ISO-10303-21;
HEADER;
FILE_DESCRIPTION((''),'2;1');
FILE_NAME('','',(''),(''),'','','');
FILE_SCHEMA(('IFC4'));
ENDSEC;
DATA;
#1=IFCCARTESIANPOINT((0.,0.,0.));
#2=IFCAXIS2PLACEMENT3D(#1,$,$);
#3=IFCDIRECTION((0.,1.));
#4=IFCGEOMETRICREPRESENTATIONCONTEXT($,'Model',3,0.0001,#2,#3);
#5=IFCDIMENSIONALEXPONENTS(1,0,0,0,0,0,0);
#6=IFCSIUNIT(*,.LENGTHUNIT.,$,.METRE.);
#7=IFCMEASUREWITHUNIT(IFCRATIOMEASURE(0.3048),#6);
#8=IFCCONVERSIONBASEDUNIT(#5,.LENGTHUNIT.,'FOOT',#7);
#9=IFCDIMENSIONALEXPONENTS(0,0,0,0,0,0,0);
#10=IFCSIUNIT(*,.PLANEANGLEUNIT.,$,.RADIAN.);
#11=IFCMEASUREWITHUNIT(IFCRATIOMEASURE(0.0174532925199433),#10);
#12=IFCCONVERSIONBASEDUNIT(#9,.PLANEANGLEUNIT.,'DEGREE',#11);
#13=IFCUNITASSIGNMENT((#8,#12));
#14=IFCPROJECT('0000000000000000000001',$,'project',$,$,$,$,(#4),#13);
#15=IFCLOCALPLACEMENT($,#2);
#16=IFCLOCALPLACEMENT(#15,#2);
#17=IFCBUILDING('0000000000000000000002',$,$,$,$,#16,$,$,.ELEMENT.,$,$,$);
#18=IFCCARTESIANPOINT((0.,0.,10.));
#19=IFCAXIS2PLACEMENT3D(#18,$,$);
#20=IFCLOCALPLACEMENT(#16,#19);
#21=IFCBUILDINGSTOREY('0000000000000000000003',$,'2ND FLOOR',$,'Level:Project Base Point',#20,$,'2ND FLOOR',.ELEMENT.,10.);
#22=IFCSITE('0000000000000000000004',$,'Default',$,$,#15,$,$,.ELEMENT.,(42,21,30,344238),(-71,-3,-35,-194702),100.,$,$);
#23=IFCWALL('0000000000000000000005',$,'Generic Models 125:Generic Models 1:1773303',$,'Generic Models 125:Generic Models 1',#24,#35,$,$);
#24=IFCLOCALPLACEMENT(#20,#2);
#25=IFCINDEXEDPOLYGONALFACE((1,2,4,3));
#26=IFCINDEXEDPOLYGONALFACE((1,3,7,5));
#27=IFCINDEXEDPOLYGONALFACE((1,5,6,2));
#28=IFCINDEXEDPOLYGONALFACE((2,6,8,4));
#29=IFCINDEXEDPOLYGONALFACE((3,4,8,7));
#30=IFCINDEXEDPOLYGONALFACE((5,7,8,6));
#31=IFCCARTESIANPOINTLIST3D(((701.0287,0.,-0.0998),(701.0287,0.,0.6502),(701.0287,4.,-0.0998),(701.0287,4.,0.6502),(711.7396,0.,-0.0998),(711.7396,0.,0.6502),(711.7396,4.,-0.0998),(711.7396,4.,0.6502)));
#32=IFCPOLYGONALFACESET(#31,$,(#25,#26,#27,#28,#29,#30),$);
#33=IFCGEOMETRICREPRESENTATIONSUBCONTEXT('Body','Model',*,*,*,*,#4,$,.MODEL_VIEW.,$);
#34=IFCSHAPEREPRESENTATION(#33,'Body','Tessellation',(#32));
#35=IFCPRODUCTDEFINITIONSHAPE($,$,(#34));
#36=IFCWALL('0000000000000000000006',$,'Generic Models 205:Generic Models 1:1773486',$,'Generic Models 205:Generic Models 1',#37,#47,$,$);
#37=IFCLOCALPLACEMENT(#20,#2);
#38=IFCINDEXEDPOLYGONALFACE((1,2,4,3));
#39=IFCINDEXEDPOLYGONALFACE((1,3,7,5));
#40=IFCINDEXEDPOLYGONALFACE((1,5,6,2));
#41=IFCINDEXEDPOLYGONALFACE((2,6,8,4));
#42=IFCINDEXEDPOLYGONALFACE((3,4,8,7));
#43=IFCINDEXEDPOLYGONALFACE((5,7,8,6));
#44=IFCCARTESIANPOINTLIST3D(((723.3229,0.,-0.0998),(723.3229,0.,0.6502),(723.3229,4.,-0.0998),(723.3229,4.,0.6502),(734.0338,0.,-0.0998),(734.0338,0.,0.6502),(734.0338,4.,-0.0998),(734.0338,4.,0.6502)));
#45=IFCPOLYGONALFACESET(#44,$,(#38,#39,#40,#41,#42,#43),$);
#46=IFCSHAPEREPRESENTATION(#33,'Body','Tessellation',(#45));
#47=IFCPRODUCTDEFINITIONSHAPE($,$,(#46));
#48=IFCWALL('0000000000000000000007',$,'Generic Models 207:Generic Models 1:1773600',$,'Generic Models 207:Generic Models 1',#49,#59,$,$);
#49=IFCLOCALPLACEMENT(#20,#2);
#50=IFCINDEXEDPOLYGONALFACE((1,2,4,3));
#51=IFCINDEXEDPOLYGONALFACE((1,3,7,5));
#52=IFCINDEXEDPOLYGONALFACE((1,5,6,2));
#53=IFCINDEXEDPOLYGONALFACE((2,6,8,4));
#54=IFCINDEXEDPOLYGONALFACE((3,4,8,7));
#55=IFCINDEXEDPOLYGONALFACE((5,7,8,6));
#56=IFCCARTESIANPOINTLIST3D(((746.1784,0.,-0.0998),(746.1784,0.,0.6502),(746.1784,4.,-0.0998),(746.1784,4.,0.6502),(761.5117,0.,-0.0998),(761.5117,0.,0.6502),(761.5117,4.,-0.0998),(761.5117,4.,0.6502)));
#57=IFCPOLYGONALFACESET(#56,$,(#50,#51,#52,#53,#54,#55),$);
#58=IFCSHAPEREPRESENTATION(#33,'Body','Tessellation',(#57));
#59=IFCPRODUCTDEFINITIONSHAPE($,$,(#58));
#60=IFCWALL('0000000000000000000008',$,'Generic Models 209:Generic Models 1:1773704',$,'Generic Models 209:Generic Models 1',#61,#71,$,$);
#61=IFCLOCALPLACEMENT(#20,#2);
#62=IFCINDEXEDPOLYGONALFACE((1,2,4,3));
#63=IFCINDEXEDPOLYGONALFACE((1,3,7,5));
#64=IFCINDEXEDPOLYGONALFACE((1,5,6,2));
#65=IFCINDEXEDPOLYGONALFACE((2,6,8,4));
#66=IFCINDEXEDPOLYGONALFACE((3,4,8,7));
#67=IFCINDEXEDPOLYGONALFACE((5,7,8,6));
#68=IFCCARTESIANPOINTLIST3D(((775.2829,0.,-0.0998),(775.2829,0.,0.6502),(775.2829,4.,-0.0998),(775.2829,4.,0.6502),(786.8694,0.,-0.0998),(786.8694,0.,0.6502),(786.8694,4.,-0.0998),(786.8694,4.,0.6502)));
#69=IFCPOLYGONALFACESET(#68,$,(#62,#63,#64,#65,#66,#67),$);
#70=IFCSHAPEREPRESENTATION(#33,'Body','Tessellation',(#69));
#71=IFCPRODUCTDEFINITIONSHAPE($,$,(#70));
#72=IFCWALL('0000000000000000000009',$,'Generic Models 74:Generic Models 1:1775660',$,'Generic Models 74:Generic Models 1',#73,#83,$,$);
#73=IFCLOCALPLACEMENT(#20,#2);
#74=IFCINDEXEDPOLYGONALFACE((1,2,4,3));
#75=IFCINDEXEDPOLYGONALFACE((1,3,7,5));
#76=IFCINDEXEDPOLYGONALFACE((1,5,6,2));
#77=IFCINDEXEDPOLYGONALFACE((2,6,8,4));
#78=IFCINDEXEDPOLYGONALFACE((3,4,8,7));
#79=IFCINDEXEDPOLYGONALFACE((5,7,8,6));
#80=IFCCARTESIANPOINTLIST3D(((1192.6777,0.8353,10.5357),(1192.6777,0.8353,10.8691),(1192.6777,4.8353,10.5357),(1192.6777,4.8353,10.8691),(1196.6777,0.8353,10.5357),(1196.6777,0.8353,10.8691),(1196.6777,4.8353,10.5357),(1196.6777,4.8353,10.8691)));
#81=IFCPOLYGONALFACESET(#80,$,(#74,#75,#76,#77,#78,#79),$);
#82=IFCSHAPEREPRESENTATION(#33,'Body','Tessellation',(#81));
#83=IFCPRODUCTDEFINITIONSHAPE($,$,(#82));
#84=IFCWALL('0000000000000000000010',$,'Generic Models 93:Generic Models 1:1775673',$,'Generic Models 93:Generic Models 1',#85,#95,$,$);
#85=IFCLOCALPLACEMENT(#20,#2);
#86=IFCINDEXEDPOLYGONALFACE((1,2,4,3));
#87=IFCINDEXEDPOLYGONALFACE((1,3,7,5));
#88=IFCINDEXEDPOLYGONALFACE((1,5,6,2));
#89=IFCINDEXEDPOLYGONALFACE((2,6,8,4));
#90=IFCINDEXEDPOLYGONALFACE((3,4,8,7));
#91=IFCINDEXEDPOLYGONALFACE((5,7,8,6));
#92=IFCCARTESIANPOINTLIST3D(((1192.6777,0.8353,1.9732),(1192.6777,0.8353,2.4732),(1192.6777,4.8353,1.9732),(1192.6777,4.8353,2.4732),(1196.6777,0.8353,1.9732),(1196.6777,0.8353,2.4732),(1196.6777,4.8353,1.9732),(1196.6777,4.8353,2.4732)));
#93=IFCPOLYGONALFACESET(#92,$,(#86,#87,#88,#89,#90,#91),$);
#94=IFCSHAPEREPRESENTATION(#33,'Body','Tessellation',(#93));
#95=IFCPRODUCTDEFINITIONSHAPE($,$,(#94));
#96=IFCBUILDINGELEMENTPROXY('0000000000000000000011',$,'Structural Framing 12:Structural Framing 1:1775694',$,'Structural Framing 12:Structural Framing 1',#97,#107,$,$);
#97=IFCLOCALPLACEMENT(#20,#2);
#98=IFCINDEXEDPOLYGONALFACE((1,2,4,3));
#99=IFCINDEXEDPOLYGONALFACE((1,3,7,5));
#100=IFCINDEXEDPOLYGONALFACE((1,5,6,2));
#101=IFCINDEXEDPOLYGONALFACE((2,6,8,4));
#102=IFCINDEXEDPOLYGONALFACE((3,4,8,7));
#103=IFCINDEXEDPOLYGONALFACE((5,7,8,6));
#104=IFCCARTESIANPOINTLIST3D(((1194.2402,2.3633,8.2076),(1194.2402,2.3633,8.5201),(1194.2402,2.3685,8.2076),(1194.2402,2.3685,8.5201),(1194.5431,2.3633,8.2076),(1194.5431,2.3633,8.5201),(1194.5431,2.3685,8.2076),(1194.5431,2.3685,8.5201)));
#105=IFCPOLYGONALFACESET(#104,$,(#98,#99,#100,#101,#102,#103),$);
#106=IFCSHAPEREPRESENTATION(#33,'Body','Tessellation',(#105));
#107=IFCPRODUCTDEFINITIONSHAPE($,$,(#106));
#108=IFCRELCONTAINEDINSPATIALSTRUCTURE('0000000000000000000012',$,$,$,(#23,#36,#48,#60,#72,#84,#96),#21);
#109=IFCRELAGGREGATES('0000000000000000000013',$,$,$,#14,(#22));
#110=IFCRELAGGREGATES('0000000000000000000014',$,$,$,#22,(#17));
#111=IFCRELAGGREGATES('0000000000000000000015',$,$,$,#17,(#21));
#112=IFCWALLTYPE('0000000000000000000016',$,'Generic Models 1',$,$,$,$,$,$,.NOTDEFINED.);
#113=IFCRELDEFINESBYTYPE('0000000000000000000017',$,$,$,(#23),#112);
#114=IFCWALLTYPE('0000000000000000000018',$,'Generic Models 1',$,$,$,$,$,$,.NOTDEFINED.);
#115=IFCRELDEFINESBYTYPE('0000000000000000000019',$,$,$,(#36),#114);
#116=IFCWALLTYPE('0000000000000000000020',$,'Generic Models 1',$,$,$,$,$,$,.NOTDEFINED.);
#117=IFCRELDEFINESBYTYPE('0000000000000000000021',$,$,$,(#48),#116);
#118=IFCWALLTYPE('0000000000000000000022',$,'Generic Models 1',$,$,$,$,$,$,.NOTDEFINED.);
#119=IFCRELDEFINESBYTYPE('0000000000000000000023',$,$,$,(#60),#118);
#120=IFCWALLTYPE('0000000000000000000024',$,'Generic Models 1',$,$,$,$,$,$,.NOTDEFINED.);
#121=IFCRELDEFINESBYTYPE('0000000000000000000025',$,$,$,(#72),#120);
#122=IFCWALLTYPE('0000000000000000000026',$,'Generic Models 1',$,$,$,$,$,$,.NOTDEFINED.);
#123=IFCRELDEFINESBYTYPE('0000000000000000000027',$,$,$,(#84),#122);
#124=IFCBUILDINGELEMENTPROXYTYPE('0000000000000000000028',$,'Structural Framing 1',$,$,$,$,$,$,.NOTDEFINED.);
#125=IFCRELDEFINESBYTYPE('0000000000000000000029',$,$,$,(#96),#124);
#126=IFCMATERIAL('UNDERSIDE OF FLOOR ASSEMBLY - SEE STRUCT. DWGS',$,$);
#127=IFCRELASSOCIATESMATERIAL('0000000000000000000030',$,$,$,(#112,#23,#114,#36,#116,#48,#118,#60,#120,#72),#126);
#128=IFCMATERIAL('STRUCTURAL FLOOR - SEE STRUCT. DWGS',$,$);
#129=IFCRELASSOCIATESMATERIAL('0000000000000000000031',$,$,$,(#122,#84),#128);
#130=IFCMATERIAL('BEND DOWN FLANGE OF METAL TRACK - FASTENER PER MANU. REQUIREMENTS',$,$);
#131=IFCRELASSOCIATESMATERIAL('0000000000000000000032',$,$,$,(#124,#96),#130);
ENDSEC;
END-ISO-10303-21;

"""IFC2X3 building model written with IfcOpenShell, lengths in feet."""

from ifc_helpers import new_model, entity, si_unit, converted_unit, direction, frame, frame_2d, origin, origin_2d_with_axis, place, context, subcontext, project, spatial, rectangle, extrude, source, transform, mapped, material, type_object, type_shapes, element, save


model = new_model("IFC2X3")

# Units and contexts
model_context = context("Model", 3, precision=0.0001, world=origin(), true_north=direction((0.0, 1.0)))
body_context = subcontext(model_context, "Body", "Model", "MODEL_VIEW")
ifc_project = project(units=[converted_unit("LENGTHUNIT", "FOOT", entity("IfcRatioMeasure", 0.3048), si_unit("LENGTHUNIT", "METRE"), dimensions=[1, 0, 0, 0, 0, 0, 0]), converted_unit("PLANEANGLEUNIT", "DEGREE", entity("IfcRatioMeasure", 0.0174532925199433), si_unit("PLANEANGLEUNIT", "RADIAN"), dimensions=[0, 0, 0, 0, 0, 0, 0])], contexts=[model_context])

# Site, building, storey
site_placement = place(None, origin())
site = spatial("IfcSite", under=ifc_project, at=site_placement, Name="Default", CompositionType="ELEMENT", RefLatitude=(42, 21, 30, 344238), RefLongitude=(-71, -3, -35, -194702), RefElevation=100.0)
building_placement = place(site_placement, origin())
building = spatial("IfcBuilding", under=site, at=building_placement, CompositionType="ELEMENT")
storey_placement = place(building_placement, frame((0.0, 0.0, 10.0)))
storey = spatial("IfcBuildingStorey", under=building, at=storey_placement, Name="2ND FLOOR", ObjectType="Level:Project Base Point", LongName="2ND FLOOR", CompositionType="ELEMENT", Elevation=10.0)

# Walls
ifc_material_1 = material(Name="UNDERSIDE OF FLOOR ASSEMBLY - SEE STRUCT. DWGS")
wall_type_1 = type_object("IfcWallType", Name="Generic Models 1", PredefinedType="NOTDEFINED", material=ifc_material_1)
wall_1_placement = place(storey_placement, frame((701.0287, 0.0, -0.0998)))
element("IfcWall", 1, at=wall_1_placement, inside=storey, type_object=wall_type_1, material=ifc_material_1, Name="Generic Models 125:Generic Models 1:1773303", ObjectType="Generic Models 125:Generic Models 1", context=body_context, shape_type="SweptSolid", body=[
    extrude(rectangle(XDim=4.0, YDim=10.7109, at=frame_2d((0.0, 0.0), x_axis=(1.0, 0.0))), frame((5.3554, 2.0, 0.0), z_axis=(0.0, 0.0, 1.0), x_axis=(0.0, 1.0, 0.0)), (0.0, 0.0, 1.0), 0.75),
])
wall_type_2 = type_object("IfcWallType", Name="Generic Models 1", PredefinedType="NOTDEFINED", material=ifc_material_1)
wall_2_placement = place(storey_placement, frame((723.3229, 0.0, -0.0998)))
element("IfcWall", 2, at=wall_2_placement, inside=storey, type_object=wall_type_2, material=ifc_material_1, Name="Generic Models 205:Generic Models 1:1773486", ObjectType="Generic Models 205:Generic Models 1", context=body_context, shape_type="SweptSolid", body=[
    extrude(rectangle(XDim=4.0, YDim=10.7109, at=frame_2d((0.0, 0.0), x_axis=(1.0, 0.0))), frame((5.3554, 2.0, 0.0), z_axis=(0.0, 0.0, 1.0), x_axis=(0.0, 1.0, 0.0)), (0.0, 0.0, 1.0), 0.75),
])
wall_type_3 = type_object("IfcWallType", Name="Generic Models 1", PredefinedType="NOTDEFINED", material=ifc_material_1)
wall_3_placement = place(storey_placement, frame((746.1784, 0.0, -0.0998)))
element("IfcWall", 3, at=wall_3_placement, inside=storey, type_object=wall_type_3, material=ifc_material_1, Name="Generic Models 207:Generic Models 1:1773600", ObjectType="Generic Models 207:Generic Models 1", context=body_context, shape_type="SweptSolid", body=[
    extrude(rectangle(XDim=4.0, YDim=15.3333, at=frame_2d((0.0, 0.0), x_axis=(1.0, 0.0))), frame((7.6667, 2.0, 0.0), z_axis=(0.0, 0.0, 1.0), x_axis=(0.0, 1.0, 0.0)), (0.0, 0.0, 1.0), 0.75),
])
wall_type_4 = type_object("IfcWallType", Name="Generic Models 1", PredefinedType="NOTDEFINED", material=ifc_material_1)
wall_4_placement = place(storey_placement, frame((775.2829, 0.0, -0.0998)))
element("IfcWall", 4, at=wall_4_placement, inside=storey, type_object=wall_type_4, material=ifc_material_1, Name="Generic Models 209:Generic Models 1:1773704", ObjectType="Generic Models 209:Generic Models 1", context=body_context, shape_type="SweptSolid", body=[
    extrude(rectangle(XDim=4.0, YDim=11.5865, at=frame_2d((0.0, 0.0), x_axis=(1.0, 0.0))), frame((5.7933, 2.0, 0.0), z_axis=(0.0, 0.0, 1.0), x_axis=(0.0, 1.0, 0.0)), (0.0, 0.0, 1.0), 0.75),
])
wall_type_5 = type_object("IfcWallType", Name="Generic Models 1", PredefinedType="NOTDEFINED", material=ifc_material_1)
wall_5_placement = place(storey_placement, frame((1192.6777, 0.8353, 10.5357), z_axis=(0.0, 0.0, 1.0), x_axis=(0.0, 1.0, 0.0)))
element("IfcWall", 5, at=wall_5_placement, inside=storey, type_object=wall_type_5, material=ifc_material_1, Name="Generic Models 74:Generic Models 1:1775660", ObjectType="Generic Models 74:Generic Models 1", context=body_context, shape_type="SweptSolid", body=[
    extrude(rectangle(XDim=4.0, YDim=4.0, at=frame_2d((0.0, 0.0), x_axis=(1.0, 0.0))), frame((2.0, -2.0, 0.0)), (0.0, 0.0, 1.0), 0.3333),
])
ifc_material_2 = material(Name="STRUCTURAL FLOOR - SEE STRUCT. DWGS")
wall_type_6 = type_object("IfcWallType", Name="Generic Models 1", PredefinedType="NOTDEFINED", material=ifc_material_2)
wall_6_placement = place(storey_placement, frame((1192.6777, 0.8353, 1.9732), z_axis=(0.0, 0.0, 1.0), x_axis=(0.0, 1.0, 0.0)))
element("IfcWall", 6, at=wall_6_placement, inside=storey, type_object=wall_type_6, material=ifc_material_2, Name="Generic Models 93:Generic Models 1:1775673", ObjectType="Generic Models 93:Generic Models 1", context=body_context, shape_type="SweptSolid", body=[
    extrude(rectangle(XDim=4.0, YDim=4.0, at=origin_2d_with_axis()), frame((2.0, -2.0, 0.0)), (0.0, 0.0, 1.0), 0.5),
])

# Building element proxy
ifc_material_3 = material(Name="BEND DOWN FLANGE OF METAL TRACK - FASTENER PER MANU. REQUIREMENTS")
building_element_proxy_type_1 = type_object("IfcBuildingElementProxyType", Name="Structural Framing 1", PredefinedType="NOTDEFINED", material=ifc_material_3)
shared_shape_1 = source(origin(), body_context, "Body", "SweptSolid", [
    extrude(rectangle(XDim=0.3029, YDim=0.0052, at=frame_2d((0.0, 0.0), x_axis=(1.0, 0.0))), frame((0.1514, 0.0026, 0.0), z_axis=(0.0, 0.0, 1.0), x_axis=(-1.0, 0.0, 0.0)), (0.0, 0.0, 1.0), 0.3125),
])
type_shapes(building_element_proxy_type_1, [shared_shape_1])
proxy_1_placement = place(storey_placement, frame((1194.2402, 2.3633, 8.2076)))
element("IfcBuildingElementProxy", 7, at=proxy_1_placement, inside=storey, type_object=building_element_proxy_type_1, material=ifc_material_3, Name="Structural Framing 12:Structural Framing 1:1775694", ObjectType="Structural Framing 12:Structural Framing 1", context=body_context, shape_type="MappedRepresentation", body=[
    mapped(shared_shape_1, transform((0.0, 0.0, 0.0), scale=1.0)),
])

save(model, "model.ifc")
